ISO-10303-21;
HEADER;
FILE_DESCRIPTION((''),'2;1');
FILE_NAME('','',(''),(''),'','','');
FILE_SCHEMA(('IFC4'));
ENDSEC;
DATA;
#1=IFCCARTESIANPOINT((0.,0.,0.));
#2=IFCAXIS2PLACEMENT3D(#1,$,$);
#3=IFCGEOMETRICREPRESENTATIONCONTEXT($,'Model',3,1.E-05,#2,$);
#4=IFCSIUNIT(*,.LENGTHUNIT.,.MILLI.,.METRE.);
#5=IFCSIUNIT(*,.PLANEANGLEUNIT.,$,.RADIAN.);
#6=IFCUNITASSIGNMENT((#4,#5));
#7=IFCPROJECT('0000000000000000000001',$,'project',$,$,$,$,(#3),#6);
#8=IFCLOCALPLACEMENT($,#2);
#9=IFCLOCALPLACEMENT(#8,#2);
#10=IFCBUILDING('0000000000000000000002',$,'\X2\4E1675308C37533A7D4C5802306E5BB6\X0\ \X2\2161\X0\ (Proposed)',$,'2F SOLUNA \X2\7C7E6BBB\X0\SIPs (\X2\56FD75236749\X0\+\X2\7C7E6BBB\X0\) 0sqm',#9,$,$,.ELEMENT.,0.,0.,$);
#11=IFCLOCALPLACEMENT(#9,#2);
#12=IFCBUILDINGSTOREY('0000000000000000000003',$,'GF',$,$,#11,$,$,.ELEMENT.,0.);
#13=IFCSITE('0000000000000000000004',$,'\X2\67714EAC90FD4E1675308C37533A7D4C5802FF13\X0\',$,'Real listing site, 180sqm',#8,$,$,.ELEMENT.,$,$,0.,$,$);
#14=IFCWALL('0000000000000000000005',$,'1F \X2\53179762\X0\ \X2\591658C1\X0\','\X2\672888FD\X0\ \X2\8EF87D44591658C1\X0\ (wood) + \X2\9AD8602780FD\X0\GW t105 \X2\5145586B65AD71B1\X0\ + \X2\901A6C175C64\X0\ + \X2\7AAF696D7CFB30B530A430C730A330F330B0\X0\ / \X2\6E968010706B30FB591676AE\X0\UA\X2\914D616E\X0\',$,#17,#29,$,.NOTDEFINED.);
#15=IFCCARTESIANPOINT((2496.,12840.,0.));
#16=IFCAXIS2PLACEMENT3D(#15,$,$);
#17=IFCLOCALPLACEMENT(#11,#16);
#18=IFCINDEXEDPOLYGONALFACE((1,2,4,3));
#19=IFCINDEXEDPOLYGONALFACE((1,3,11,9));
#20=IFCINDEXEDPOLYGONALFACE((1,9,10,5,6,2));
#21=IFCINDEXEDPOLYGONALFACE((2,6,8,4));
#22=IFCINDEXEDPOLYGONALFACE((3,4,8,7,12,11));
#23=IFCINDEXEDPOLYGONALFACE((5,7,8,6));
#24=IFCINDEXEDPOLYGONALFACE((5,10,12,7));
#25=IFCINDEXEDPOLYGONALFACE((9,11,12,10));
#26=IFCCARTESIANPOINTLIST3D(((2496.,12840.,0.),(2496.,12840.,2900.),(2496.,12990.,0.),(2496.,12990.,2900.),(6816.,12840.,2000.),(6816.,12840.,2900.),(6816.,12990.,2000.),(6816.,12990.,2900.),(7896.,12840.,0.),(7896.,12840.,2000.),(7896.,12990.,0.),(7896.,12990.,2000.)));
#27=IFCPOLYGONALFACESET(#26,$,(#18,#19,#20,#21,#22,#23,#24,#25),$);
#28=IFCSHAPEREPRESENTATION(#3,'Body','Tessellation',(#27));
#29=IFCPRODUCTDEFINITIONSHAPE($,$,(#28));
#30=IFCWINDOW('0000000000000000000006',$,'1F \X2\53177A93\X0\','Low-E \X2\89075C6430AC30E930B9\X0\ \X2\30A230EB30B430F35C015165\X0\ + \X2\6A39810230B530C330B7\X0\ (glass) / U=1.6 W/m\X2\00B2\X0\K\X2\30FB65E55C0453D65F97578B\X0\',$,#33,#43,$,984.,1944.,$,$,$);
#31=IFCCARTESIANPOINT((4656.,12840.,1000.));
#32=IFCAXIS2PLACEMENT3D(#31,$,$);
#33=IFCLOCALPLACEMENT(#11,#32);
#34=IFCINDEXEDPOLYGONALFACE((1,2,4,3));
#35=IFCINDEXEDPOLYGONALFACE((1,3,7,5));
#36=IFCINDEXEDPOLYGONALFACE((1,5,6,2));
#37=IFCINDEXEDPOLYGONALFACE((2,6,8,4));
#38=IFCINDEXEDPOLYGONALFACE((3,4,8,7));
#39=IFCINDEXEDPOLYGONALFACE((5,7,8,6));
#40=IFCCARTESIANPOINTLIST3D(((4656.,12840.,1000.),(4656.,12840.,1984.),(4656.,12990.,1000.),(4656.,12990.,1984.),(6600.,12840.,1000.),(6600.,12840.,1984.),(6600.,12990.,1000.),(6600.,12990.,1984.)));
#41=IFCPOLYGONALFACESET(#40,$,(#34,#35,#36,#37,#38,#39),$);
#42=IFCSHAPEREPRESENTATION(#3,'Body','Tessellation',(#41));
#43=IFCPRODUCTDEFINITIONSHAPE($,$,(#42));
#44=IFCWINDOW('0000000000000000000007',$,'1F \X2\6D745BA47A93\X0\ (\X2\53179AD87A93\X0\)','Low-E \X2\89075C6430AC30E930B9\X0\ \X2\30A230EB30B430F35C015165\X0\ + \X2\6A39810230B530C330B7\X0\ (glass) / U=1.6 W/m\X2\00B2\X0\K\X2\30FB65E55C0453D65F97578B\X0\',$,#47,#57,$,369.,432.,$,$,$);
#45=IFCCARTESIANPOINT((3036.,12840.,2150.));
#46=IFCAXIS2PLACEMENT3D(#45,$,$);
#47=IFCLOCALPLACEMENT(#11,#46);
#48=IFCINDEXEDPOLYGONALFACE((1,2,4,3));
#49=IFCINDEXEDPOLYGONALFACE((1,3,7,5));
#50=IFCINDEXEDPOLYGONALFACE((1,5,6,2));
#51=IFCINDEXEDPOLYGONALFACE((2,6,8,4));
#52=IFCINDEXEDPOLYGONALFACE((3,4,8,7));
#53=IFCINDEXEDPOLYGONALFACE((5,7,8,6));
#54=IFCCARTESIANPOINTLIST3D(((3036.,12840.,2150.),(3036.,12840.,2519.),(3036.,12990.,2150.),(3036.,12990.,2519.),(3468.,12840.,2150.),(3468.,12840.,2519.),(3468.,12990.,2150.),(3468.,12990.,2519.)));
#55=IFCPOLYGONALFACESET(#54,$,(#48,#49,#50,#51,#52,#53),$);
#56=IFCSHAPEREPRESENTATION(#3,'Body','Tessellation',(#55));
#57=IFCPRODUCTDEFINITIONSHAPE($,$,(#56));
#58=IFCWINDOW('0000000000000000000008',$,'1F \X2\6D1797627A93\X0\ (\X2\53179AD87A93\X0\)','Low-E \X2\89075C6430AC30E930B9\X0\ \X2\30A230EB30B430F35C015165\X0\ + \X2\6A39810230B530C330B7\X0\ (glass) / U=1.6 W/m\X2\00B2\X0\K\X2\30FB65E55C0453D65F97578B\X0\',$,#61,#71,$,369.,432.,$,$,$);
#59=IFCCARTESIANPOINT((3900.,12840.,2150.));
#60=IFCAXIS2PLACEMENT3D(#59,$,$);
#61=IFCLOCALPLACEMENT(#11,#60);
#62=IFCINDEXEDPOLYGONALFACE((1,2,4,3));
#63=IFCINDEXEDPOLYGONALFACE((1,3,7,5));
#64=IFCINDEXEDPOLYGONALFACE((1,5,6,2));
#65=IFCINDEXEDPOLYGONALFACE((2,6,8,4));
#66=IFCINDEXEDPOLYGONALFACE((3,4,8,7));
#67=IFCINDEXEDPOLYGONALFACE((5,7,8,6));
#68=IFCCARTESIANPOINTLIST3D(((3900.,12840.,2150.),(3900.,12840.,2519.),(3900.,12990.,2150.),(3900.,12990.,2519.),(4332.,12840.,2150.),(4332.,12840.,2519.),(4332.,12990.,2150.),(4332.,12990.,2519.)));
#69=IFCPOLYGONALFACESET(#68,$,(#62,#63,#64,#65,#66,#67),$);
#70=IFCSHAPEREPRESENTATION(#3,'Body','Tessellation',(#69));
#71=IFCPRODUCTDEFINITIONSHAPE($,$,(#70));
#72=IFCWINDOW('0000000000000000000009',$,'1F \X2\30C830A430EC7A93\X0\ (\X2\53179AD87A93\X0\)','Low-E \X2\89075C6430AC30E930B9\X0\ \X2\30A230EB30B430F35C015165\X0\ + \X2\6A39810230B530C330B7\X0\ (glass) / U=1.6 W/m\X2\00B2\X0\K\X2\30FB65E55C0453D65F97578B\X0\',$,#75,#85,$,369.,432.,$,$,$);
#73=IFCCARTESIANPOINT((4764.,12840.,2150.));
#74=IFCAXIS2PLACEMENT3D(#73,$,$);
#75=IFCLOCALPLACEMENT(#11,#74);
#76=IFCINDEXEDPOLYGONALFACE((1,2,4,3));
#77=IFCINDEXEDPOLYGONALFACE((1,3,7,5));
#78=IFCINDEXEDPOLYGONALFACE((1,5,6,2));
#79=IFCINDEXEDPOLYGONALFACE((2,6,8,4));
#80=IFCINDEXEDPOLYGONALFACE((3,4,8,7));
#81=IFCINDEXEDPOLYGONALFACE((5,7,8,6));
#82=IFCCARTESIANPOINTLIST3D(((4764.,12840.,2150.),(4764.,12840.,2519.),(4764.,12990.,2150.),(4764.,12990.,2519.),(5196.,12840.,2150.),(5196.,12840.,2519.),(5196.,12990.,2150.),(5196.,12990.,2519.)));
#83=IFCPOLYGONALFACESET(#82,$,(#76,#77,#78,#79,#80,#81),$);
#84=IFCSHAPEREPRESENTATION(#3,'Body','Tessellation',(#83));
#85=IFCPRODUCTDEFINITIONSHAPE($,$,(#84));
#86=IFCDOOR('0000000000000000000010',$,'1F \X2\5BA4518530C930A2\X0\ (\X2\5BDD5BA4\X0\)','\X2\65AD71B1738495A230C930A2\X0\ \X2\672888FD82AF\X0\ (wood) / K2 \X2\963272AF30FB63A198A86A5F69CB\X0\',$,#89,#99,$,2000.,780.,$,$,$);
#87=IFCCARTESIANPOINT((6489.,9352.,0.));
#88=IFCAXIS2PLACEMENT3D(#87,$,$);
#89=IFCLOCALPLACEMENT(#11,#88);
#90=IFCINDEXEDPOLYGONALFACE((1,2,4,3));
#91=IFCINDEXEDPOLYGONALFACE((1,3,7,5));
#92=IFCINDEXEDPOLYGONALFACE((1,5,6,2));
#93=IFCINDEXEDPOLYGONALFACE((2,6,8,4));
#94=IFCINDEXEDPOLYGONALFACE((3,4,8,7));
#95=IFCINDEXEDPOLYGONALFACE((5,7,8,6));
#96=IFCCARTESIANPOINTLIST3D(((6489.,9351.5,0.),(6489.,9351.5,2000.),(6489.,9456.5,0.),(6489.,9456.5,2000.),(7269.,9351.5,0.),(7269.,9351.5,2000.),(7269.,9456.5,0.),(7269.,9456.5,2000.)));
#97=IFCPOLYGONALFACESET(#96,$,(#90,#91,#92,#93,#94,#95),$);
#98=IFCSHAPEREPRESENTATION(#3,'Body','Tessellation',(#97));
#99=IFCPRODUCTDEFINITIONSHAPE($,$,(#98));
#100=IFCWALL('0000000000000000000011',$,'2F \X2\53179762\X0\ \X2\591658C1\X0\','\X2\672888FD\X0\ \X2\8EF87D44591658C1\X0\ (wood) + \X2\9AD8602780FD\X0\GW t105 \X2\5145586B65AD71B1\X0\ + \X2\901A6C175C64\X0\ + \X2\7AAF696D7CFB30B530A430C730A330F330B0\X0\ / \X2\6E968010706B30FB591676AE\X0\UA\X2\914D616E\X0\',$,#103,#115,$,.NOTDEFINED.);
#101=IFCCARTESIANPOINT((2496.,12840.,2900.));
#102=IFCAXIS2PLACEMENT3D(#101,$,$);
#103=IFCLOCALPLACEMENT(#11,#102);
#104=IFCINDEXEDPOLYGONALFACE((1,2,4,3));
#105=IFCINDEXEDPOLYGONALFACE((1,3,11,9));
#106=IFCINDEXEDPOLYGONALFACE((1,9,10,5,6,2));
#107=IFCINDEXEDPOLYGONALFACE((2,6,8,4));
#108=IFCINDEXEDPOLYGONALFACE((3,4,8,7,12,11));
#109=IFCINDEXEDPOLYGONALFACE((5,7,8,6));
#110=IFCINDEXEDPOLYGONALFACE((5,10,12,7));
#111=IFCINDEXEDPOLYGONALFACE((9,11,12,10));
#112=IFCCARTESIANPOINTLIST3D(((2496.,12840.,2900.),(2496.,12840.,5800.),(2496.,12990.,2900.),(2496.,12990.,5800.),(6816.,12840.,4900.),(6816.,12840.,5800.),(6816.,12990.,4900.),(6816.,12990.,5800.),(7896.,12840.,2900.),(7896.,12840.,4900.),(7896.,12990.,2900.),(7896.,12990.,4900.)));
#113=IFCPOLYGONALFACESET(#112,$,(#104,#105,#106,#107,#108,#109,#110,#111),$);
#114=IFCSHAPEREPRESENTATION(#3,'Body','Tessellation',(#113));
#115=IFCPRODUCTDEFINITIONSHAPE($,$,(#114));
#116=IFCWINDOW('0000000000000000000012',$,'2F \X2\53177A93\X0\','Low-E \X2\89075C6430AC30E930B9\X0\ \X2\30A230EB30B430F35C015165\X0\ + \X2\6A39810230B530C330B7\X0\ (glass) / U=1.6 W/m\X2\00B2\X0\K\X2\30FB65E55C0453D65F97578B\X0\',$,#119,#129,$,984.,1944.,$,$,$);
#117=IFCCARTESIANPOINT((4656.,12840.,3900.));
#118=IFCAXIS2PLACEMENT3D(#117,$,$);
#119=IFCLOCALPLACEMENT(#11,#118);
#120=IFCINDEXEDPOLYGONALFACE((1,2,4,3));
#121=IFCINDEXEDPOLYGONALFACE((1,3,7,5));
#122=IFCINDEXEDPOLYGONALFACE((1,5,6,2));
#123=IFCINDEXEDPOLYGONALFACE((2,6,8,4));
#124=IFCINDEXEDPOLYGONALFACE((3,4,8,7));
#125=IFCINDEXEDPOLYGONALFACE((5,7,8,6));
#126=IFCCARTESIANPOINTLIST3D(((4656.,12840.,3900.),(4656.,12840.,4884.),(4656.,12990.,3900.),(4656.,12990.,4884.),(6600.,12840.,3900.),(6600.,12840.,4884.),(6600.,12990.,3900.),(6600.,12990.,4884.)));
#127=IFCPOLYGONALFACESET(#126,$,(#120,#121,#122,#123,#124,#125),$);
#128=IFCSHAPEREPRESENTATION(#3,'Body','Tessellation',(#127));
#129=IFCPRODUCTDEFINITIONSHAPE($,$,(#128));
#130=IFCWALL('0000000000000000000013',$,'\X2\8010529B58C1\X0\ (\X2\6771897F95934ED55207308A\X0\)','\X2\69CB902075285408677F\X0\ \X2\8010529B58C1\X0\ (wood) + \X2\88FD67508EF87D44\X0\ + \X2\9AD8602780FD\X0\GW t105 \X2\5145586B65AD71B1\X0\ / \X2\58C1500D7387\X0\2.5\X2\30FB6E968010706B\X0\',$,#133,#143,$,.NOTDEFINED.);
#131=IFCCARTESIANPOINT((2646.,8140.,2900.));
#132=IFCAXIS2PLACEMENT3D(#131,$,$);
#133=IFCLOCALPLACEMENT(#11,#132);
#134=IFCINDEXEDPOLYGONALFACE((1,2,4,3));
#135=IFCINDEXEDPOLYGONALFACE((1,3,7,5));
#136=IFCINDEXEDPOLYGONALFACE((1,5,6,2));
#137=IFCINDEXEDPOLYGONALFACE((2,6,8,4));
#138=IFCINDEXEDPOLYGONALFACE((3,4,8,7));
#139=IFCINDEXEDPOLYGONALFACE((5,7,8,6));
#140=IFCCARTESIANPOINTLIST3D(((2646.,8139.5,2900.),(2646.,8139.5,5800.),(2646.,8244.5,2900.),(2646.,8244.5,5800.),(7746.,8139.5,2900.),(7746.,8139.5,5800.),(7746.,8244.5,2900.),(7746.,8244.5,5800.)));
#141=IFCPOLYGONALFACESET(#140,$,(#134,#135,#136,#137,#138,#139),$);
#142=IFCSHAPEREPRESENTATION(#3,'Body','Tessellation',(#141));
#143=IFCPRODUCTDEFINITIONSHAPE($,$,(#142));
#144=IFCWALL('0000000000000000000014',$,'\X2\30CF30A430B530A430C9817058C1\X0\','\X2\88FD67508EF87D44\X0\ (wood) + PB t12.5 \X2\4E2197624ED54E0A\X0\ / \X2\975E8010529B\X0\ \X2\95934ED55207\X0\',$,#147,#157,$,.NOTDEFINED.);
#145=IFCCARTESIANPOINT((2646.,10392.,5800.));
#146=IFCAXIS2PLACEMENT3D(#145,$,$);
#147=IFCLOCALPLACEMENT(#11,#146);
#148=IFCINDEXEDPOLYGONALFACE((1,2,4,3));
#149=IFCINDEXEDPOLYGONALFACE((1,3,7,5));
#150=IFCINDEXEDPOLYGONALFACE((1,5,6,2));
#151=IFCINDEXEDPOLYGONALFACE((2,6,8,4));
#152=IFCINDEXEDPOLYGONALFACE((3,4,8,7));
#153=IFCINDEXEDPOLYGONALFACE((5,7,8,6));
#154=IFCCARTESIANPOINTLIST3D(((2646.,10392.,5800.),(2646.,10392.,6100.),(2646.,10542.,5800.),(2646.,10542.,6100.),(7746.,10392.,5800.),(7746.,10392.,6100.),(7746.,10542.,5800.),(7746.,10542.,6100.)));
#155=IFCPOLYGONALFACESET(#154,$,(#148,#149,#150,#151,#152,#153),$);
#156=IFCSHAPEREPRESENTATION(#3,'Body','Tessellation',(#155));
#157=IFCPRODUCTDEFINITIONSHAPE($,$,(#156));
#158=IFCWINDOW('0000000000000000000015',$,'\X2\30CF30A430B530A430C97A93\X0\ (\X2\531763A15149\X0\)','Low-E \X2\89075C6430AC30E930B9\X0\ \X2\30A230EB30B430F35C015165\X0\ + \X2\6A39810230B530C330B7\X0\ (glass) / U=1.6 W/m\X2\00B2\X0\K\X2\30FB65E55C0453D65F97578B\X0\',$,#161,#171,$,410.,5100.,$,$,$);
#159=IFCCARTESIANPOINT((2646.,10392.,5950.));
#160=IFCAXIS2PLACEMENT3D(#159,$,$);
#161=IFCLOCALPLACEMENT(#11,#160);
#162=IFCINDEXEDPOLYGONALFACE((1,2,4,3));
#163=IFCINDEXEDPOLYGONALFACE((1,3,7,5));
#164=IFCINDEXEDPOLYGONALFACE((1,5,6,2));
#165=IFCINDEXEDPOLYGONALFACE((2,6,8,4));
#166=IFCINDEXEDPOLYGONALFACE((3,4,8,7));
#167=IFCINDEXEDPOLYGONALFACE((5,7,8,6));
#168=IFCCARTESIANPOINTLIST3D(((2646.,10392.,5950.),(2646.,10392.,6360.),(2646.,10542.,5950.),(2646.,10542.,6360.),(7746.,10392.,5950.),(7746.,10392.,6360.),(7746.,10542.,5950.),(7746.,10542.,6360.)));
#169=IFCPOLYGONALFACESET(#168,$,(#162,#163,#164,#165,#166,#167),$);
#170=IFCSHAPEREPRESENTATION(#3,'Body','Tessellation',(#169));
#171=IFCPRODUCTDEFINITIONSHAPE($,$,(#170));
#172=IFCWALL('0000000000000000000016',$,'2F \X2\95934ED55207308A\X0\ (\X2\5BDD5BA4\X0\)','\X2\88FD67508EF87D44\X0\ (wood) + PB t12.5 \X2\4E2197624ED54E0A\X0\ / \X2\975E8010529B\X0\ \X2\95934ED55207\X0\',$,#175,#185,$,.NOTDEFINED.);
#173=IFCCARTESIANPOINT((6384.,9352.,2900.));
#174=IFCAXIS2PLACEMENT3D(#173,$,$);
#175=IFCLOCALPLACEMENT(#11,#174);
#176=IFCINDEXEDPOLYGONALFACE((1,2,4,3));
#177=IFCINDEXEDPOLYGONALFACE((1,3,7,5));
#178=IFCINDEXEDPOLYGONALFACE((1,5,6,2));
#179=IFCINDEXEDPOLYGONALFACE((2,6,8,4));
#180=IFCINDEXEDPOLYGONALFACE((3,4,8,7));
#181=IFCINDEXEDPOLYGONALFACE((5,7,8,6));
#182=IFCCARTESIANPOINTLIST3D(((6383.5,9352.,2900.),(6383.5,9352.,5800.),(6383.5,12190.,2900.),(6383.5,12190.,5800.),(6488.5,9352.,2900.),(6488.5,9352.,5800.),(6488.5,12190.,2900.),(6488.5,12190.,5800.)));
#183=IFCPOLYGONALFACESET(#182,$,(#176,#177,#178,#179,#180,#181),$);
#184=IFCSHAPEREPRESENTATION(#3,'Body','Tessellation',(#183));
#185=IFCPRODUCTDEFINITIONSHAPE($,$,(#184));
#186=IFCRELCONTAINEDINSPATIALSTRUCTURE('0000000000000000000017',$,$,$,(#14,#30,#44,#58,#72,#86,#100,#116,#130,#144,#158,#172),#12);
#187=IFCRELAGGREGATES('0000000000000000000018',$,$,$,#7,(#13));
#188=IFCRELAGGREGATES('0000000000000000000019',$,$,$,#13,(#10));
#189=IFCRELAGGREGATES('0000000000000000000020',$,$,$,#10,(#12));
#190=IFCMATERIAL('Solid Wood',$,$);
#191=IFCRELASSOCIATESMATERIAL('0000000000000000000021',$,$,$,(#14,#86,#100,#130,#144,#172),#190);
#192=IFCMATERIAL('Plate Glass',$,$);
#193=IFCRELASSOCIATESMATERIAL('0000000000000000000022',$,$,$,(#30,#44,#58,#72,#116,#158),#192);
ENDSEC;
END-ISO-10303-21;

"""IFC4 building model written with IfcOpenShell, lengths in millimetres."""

from ifc_helpers import new_model, si_unit, frame, frame_2d, origin, place, context, project, spatial, rectangle, extrude, material, element, fill, save


model = new_model("IFC4")

# Units and contexts
model_context = context("Model", 3, precision=1e-05, world=origin())
ifc_project = project(units=[si_unit("LENGTHUNIT", "METRE", prefix="MILLI"), si_unit("PLANEANGLEUNIT", "RADIAN")], contexts=[model_context])

# Site, building, storey
site_placement = place(None, origin())
site = spatial("IfcSite", under=ifc_project, at=site_placement, Name="東京都世田谷区経堂３", ObjectType="Real listing site, 180sqm", CompositionType="ELEMENT", RefElevation=0.0)
building_placement = place(site_placement, origin())
building = spatial("IfcBuilding", under=site, at=building_placement, Name="世田谷区経堂の家 Ⅱ (Proposed)", ObjectType="2F SOLUNA 籾殻SIPs (国産杉+籾殻) 0sqm", CompositionType="ELEMENT", ElevationOfRefHeight=0.0, ElevationOfTerrain=0.0)
storey_placement = place(building_placement, origin())
storey = spatial("IfcBuildingStorey", under=building, at=storey_placement, Name="GF", CompositionType="ELEMENT", Elevation=0.0)

# Wall, openings, windows
ifc_material_1 = material(Name="Solid Wood")
wall_1_placement = place(storey_placement, frame((2496.0, 12840.0, 0.0)))
wall_1 = element("IfcWall", 1, at=wall_1_placement, inside=storey, material=ifc_material_1, Name="1F 北面 外壁", Description="木製 軸組外壁 (wood) + 高性能GW t105 充填断熱 + 通気層 + 窯業系サイディング / 準耐火・外皮UA配慮", PredefinedType="NOTDEFINED", context=model_context, shape_type="SweptSolid", body=[
    extrude(rectangle(XDim=5400.0, YDim=150.0, at=frame_2d((2700.0, 75.0))), frame((2496.0, 12840.0, 0.0)), (0.0, 0.0, 1.0), 2900.0),
])
opening_1_placement = place(storey_placement, frame((4656.0, 12840.0, 1000.0)))
opening_1 = element("IfcOpeningElement", 2, at=opening_1_placement, cuts=wall_1, PredefinedType="NOTDEFINED", context=model_context, shape_type="SweptSolid", body=[
    extrude(rectangle(XDim=1944.0, YDim=150.0, at=frame_2d((972.0, 75.0))), frame((4656.0, 12840.0, 1000.0)), (0.0, 0.0, 1.0), 984.0),
])
opening_2_placement = place(storey_placement, frame((3036.0, 12840.0, 2150.0)))
opening_2 = element("IfcOpeningElement", 3, at=opening_2_placement, cuts=wall_1, PredefinedType="NOTDEFINED", context=model_context, shape_type="SweptSolid", body=[
    extrude(rectangle(XDim=432.0, YDim=150.0, at=frame_2d((216.0, 75.0))), frame((3036.0, 12840.0, 2150.0)), (0.0, 0.0, 1.0), 369.0),
])
opening_3_placement = place(storey_placement, frame((3900.0, 12840.0, 2150.0)))
opening_3 = element("IfcOpeningElement", 4, at=opening_3_placement, cuts=wall_1, PredefinedType="NOTDEFINED", context=model_context, shape_type="SweptSolid", body=[
    extrude(rectangle(XDim=432.0, YDim=150.0, at=frame_2d((216.0, 75.0))), frame((3900.0, 12840.0, 2150.0)), (0.0, 0.0, 1.0), 369.0),
])
opening_4_placement = place(storey_placement, frame((4764.0, 12840.0, 2150.0)))
opening_4 = element("IfcOpeningElement", 5, at=opening_4_placement, cuts=wall_1, PredefinedType="NOTDEFINED", context=model_context, shape_type="SweptSolid", body=[
    extrude(rectangle(XDim=432.0, YDim=150.0, at=frame_2d((216.0, 75.0))), frame((4764.0, 12840.0, 2150.0)), (0.0, 0.0, 1.0), 369.0),
])
ifc_material_2 = material(Name="Plate Glass")
window_1_placement = place(storey_placement, frame((4656.0, 12840.0, 1000.0)))
window_1 = element("IfcWindow", 6, at=window_1_placement, inside=storey, material=ifc_material_2, Name="1F 北窓", Description="Low-E 複層ガラス アルゴン封入 + 樹脂サッシ (glass) / U=1.6 W/m²K・日射取得型", OverallHeight=984.0, OverallWidth=1944.0, context=model_context, shape_type="SweptSolid", body=[
    extrude(rectangle(XDim=1944.0, YDim=150.0, at=frame_2d((972.0, 75.0))), frame((4656.0, 12840.0, 1000.0)), (0.0, 0.0, 1.0), 984.0),
])
fill(opening_1, window_1)
window_2_placement = place(storey_placement, frame((3036.0, 12840.0, 2150.0)))
window_2 = element("IfcWindow", 7, at=window_2_placement, inside=storey, material=ifc_material_2, Name="1F 浴室窓 (北高窓)", Description="Low-E 複層ガラス アルゴン封入 + 樹脂サッシ (glass) / U=1.6 W/m²K・日射取得型", OverallHeight=369.0, OverallWidth=432.0, context=model_context, shape_type="SweptSolid", body=[
    extrude(rectangle(XDim=432.0, YDim=150.0, at=frame_2d((216.0, 75.0))), frame((3036.0, 12840.0, 2150.0)), (0.0, 0.0, 1.0), 369.0),
])
fill(opening_2, window_2)
window_3_placement = place(storey_placement, frame((3900.0, 12840.0, 2150.0)))
window_3 = element("IfcWindow", 8, at=window_3_placement, inside=storey, material=ifc_material_2, Name="1F 洗面窓 (北高窓)", Description="Low-E 複層ガラス アルゴン封入 + 樹脂サッシ (glass) / U=1.6 W/m²K・日射取得型", OverallHeight=369.0, OverallWidth=432.0, context=model_context, shape_type="SweptSolid", body=[
    extrude(rectangle(XDim=432.0, YDim=150.0, at=frame_2d((216.0, 75.0))), frame((3900.0, 12840.0, 2150.0)), (0.0, 0.0, 1.0), 369.0),
])
fill(opening_3, window_3)
window_4_placement = place(storey_placement, frame((4764.0, 12840.0, 2150.0)))
window_4 = element("IfcWindow", 9, at=window_4_placement, inside=storey, material=ifc_material_2, Name="1F トイレ窓 (北高窓)", Description="Low-E 複層ガラス アルゴン封入 + 樹脂サッシ (glass) / U=1.6 W/m²K・日射取得型", OverallHeight=369.0, OverallWidth=432.0, context=model_context, shape_type="SweptSolid", body=[
    extrude(rectangle(XDim=432.0, YDim=150.0, at=frame_2d((216.0, 75.0))), frame((4764.0, 12840.0, 2150.0)), (0.0, 0.0, 1.0), 369.0),
])
fill(opening_4, window_4)

# Door
door_1_placement = place(storey_placement, frame((6489.0, 9352.0, 0.0)))
element("IfcDoor", 10, at=door_1_placement, inside=storey, material=ifc_material_1, Name="1F 室内ドア (寝室)", Description="断熱玄関ドア 木製芯 (wood) / K2 防犯・採風機構", OverallHeight=2000.0, OverallWidth=780.0, context=model_context, shape_type="SweptSolid", body=[
    extrude(rectangle(XDim=780.0, YDim=105.0, at=frame_2d((390.0, 52.0))), frame((6489.0, 9352.0, 0.0)), (0.0, 0.0, 1.0), 2000.0),
])

# Wall, opening, window
wall_2_placement = place(storey_placement, frame((2496.0, 12840.0, 2900.0)))
wall_2 = element("IfcWall", 11, at=wall_2_placement, inside=storey, material=ifc_material_1, Name="2F 北面 外壁", Description="木製 軸組外壁 (wood) + 高性能GW t105 充填断熱 + 通気層 + 窯業系サイディング / 準耐火・外皮UA配慮", PredefinedType="NOTDEFINED", context=model_context, shape_type="SweptSolid", body=[
    extrude(rectangle(XDim=5400.0, YDim=150.0, at=frame_2d((2700.0, 75.0))), frame((2496.0, 12840.0, 2900.0)), (0.0, 0.0, 1.0), 2900.0),
])
opening_5_placement = place(storey_placement, frame((4656.0, 12840.0, 3900.0)))
opening_5 = element("IfcOpeningElement", 12, at=opening_5_placement, cuts=wall_2, PredefinedType="NOTDEFINED", context=model_context, shape_type="SweptSolid", body=[
    extrude(rectangle(XDim=1944.0, YDim=150.0, at=frame_2d((972.0, 75.0))), frame((4656.0, 12840.0, 3900.0)), (0.0, 0.0, 1.0), 984.0),
])
window_5_placement = place(storey_placement, frame((4656.0, 12840.0, 3900.0)))
window_5 = element("IfcWindow", 13, at=window_5_placement, inside=storey, material=ifc_material_2, Name="2F 北窓", Description="Low-E 複層ガラス アルゴン封入 + 樹脂サッシ (glass) / U=1.6 W/m²K・日射取得型", OverallHeight=984.0, OverallWidth=1944.0, context=model_context, shape_type="SweptSolid", body=[
    extrude(rectangle(XDim=1944.0, YDim=150.0, at=frame_2d((972.0, 75.0))), frame((4656.0, 12840.0, 3900.0)), (0.0, 0.0, 1.0), 984.0),
])
fill(opening_5, window_5)

# Wall
wall_3_placement = place(storey_placement, frame((2646.0, 8140.0, 2900.0)))
element("IfcWall", 14, at=wall_3_placement, inside=storey, material=ifc_material_1, Name="耐力壁 (東西間仕切り)", Description="構造用合板 耐力壁 (wood) + 製材軸組 + 高性能GW t105 充填断熱 / 壁倍率2.5・準耐火", PredefinedType="NOTDEFINED", context=model_context, shape_type="SweptSolid", body=[
    extrude(rectangle(XDim=5100.0, YDim=105.0, at=frame_2d((2550.0, 52.0))), frame((2646.0, 8140.0, 2900.0)), (0.0, 0.0, 1.0), 2900.0),
])

# Wall, opening, window
wall_4_placement = place(storey_placement, frame((2646.0, 10392.0, 5800.0)))
wall_4 = element("IfcWall", 15, at=wall_4_placement, inside=storey, material=ifc_material_1, Name="ハイサイド腰壁", Description="製材軸組 (wood) + PB t12.5 両面仕上 / 非耐力 間仕切", PredefinedType="NOTDEFINED", context=model_context, shape_type="SweptSolid", body=[
    extrude(rectangle(XDim=5100.0, YDim=150.0, at=frame_2d((2550.0, 75.0))), frame((2646.0, 10392.0, 5800.0)), (0.0, 0.0, 1.0), 700.0),
])
opening_6_placement = place(storey_placement, frame((2646.0, 10392.0, 5950.0)))
opening_6 = element("IfcOpeningElement", 16, at=opening_6_placement, cuts=wall_4, PredefinedType="NOTDEFINED", context=model_context, shape_type="SweptSolid", body=[
    extrude(rectangle(XDim=5100.0, YDim=150.0, at=frame_2d((2550.0, 75.0))), frame((2646.0, 10392.0, 5950.0)), (0.0, 0.0, 1.0), 410.0),
])
window_6_placement = place(storey_placement, frame((2646.0, 10392.0, 5950.0)))
window_6 = element("IfcWindow", 17, at=window_6_placement, inside=storey, material=ifc_material_2, Name="ハイサイド窓 (北採光)", Description="Low-E 複層ガラス アルゴン封入 + 樹脂サッシ (glass) / U=1.6 W/m²K・日射取得型", OverallHeight=410.0, OverallWidth=5100.0, context=model_context, shape_type="SweptSolid", body=[
    extrude(rectangle(XDim=5100.0, YDim=150.0, at=frame_2d((2550.0, 75.0))), frame((2646.0, 10392.0, 5950.0)), (0.0, 0.0, 1.0), 410.0),
])
fill(opening_6, window_6)

# Wall
wall_5_placement = place(storey_placement, frame((6384.0, 9352.0, 2900.0)))
element("IfcWall", 18, at=wall_5_placement, inside=storey, material=ifc_material_1, Name="2F 間仕切り (寝室)", Description="製材軸組 (wood) + PB t12.5 両面仕上 / 非耐力 間仕切", PredefinedType="NOTDEFINED", context=model_context, shape_type="SweptSolid", body=[
    extrude(rectangle(XDim=105.0, YDim=2838.0, at=frame_2d((52.0, 1419.0))), frame((6384.0, 9352.0, 2900.0)), (0.0, 0.0, 1.0), 2900.0),
])

save(model, "model.ifc")
